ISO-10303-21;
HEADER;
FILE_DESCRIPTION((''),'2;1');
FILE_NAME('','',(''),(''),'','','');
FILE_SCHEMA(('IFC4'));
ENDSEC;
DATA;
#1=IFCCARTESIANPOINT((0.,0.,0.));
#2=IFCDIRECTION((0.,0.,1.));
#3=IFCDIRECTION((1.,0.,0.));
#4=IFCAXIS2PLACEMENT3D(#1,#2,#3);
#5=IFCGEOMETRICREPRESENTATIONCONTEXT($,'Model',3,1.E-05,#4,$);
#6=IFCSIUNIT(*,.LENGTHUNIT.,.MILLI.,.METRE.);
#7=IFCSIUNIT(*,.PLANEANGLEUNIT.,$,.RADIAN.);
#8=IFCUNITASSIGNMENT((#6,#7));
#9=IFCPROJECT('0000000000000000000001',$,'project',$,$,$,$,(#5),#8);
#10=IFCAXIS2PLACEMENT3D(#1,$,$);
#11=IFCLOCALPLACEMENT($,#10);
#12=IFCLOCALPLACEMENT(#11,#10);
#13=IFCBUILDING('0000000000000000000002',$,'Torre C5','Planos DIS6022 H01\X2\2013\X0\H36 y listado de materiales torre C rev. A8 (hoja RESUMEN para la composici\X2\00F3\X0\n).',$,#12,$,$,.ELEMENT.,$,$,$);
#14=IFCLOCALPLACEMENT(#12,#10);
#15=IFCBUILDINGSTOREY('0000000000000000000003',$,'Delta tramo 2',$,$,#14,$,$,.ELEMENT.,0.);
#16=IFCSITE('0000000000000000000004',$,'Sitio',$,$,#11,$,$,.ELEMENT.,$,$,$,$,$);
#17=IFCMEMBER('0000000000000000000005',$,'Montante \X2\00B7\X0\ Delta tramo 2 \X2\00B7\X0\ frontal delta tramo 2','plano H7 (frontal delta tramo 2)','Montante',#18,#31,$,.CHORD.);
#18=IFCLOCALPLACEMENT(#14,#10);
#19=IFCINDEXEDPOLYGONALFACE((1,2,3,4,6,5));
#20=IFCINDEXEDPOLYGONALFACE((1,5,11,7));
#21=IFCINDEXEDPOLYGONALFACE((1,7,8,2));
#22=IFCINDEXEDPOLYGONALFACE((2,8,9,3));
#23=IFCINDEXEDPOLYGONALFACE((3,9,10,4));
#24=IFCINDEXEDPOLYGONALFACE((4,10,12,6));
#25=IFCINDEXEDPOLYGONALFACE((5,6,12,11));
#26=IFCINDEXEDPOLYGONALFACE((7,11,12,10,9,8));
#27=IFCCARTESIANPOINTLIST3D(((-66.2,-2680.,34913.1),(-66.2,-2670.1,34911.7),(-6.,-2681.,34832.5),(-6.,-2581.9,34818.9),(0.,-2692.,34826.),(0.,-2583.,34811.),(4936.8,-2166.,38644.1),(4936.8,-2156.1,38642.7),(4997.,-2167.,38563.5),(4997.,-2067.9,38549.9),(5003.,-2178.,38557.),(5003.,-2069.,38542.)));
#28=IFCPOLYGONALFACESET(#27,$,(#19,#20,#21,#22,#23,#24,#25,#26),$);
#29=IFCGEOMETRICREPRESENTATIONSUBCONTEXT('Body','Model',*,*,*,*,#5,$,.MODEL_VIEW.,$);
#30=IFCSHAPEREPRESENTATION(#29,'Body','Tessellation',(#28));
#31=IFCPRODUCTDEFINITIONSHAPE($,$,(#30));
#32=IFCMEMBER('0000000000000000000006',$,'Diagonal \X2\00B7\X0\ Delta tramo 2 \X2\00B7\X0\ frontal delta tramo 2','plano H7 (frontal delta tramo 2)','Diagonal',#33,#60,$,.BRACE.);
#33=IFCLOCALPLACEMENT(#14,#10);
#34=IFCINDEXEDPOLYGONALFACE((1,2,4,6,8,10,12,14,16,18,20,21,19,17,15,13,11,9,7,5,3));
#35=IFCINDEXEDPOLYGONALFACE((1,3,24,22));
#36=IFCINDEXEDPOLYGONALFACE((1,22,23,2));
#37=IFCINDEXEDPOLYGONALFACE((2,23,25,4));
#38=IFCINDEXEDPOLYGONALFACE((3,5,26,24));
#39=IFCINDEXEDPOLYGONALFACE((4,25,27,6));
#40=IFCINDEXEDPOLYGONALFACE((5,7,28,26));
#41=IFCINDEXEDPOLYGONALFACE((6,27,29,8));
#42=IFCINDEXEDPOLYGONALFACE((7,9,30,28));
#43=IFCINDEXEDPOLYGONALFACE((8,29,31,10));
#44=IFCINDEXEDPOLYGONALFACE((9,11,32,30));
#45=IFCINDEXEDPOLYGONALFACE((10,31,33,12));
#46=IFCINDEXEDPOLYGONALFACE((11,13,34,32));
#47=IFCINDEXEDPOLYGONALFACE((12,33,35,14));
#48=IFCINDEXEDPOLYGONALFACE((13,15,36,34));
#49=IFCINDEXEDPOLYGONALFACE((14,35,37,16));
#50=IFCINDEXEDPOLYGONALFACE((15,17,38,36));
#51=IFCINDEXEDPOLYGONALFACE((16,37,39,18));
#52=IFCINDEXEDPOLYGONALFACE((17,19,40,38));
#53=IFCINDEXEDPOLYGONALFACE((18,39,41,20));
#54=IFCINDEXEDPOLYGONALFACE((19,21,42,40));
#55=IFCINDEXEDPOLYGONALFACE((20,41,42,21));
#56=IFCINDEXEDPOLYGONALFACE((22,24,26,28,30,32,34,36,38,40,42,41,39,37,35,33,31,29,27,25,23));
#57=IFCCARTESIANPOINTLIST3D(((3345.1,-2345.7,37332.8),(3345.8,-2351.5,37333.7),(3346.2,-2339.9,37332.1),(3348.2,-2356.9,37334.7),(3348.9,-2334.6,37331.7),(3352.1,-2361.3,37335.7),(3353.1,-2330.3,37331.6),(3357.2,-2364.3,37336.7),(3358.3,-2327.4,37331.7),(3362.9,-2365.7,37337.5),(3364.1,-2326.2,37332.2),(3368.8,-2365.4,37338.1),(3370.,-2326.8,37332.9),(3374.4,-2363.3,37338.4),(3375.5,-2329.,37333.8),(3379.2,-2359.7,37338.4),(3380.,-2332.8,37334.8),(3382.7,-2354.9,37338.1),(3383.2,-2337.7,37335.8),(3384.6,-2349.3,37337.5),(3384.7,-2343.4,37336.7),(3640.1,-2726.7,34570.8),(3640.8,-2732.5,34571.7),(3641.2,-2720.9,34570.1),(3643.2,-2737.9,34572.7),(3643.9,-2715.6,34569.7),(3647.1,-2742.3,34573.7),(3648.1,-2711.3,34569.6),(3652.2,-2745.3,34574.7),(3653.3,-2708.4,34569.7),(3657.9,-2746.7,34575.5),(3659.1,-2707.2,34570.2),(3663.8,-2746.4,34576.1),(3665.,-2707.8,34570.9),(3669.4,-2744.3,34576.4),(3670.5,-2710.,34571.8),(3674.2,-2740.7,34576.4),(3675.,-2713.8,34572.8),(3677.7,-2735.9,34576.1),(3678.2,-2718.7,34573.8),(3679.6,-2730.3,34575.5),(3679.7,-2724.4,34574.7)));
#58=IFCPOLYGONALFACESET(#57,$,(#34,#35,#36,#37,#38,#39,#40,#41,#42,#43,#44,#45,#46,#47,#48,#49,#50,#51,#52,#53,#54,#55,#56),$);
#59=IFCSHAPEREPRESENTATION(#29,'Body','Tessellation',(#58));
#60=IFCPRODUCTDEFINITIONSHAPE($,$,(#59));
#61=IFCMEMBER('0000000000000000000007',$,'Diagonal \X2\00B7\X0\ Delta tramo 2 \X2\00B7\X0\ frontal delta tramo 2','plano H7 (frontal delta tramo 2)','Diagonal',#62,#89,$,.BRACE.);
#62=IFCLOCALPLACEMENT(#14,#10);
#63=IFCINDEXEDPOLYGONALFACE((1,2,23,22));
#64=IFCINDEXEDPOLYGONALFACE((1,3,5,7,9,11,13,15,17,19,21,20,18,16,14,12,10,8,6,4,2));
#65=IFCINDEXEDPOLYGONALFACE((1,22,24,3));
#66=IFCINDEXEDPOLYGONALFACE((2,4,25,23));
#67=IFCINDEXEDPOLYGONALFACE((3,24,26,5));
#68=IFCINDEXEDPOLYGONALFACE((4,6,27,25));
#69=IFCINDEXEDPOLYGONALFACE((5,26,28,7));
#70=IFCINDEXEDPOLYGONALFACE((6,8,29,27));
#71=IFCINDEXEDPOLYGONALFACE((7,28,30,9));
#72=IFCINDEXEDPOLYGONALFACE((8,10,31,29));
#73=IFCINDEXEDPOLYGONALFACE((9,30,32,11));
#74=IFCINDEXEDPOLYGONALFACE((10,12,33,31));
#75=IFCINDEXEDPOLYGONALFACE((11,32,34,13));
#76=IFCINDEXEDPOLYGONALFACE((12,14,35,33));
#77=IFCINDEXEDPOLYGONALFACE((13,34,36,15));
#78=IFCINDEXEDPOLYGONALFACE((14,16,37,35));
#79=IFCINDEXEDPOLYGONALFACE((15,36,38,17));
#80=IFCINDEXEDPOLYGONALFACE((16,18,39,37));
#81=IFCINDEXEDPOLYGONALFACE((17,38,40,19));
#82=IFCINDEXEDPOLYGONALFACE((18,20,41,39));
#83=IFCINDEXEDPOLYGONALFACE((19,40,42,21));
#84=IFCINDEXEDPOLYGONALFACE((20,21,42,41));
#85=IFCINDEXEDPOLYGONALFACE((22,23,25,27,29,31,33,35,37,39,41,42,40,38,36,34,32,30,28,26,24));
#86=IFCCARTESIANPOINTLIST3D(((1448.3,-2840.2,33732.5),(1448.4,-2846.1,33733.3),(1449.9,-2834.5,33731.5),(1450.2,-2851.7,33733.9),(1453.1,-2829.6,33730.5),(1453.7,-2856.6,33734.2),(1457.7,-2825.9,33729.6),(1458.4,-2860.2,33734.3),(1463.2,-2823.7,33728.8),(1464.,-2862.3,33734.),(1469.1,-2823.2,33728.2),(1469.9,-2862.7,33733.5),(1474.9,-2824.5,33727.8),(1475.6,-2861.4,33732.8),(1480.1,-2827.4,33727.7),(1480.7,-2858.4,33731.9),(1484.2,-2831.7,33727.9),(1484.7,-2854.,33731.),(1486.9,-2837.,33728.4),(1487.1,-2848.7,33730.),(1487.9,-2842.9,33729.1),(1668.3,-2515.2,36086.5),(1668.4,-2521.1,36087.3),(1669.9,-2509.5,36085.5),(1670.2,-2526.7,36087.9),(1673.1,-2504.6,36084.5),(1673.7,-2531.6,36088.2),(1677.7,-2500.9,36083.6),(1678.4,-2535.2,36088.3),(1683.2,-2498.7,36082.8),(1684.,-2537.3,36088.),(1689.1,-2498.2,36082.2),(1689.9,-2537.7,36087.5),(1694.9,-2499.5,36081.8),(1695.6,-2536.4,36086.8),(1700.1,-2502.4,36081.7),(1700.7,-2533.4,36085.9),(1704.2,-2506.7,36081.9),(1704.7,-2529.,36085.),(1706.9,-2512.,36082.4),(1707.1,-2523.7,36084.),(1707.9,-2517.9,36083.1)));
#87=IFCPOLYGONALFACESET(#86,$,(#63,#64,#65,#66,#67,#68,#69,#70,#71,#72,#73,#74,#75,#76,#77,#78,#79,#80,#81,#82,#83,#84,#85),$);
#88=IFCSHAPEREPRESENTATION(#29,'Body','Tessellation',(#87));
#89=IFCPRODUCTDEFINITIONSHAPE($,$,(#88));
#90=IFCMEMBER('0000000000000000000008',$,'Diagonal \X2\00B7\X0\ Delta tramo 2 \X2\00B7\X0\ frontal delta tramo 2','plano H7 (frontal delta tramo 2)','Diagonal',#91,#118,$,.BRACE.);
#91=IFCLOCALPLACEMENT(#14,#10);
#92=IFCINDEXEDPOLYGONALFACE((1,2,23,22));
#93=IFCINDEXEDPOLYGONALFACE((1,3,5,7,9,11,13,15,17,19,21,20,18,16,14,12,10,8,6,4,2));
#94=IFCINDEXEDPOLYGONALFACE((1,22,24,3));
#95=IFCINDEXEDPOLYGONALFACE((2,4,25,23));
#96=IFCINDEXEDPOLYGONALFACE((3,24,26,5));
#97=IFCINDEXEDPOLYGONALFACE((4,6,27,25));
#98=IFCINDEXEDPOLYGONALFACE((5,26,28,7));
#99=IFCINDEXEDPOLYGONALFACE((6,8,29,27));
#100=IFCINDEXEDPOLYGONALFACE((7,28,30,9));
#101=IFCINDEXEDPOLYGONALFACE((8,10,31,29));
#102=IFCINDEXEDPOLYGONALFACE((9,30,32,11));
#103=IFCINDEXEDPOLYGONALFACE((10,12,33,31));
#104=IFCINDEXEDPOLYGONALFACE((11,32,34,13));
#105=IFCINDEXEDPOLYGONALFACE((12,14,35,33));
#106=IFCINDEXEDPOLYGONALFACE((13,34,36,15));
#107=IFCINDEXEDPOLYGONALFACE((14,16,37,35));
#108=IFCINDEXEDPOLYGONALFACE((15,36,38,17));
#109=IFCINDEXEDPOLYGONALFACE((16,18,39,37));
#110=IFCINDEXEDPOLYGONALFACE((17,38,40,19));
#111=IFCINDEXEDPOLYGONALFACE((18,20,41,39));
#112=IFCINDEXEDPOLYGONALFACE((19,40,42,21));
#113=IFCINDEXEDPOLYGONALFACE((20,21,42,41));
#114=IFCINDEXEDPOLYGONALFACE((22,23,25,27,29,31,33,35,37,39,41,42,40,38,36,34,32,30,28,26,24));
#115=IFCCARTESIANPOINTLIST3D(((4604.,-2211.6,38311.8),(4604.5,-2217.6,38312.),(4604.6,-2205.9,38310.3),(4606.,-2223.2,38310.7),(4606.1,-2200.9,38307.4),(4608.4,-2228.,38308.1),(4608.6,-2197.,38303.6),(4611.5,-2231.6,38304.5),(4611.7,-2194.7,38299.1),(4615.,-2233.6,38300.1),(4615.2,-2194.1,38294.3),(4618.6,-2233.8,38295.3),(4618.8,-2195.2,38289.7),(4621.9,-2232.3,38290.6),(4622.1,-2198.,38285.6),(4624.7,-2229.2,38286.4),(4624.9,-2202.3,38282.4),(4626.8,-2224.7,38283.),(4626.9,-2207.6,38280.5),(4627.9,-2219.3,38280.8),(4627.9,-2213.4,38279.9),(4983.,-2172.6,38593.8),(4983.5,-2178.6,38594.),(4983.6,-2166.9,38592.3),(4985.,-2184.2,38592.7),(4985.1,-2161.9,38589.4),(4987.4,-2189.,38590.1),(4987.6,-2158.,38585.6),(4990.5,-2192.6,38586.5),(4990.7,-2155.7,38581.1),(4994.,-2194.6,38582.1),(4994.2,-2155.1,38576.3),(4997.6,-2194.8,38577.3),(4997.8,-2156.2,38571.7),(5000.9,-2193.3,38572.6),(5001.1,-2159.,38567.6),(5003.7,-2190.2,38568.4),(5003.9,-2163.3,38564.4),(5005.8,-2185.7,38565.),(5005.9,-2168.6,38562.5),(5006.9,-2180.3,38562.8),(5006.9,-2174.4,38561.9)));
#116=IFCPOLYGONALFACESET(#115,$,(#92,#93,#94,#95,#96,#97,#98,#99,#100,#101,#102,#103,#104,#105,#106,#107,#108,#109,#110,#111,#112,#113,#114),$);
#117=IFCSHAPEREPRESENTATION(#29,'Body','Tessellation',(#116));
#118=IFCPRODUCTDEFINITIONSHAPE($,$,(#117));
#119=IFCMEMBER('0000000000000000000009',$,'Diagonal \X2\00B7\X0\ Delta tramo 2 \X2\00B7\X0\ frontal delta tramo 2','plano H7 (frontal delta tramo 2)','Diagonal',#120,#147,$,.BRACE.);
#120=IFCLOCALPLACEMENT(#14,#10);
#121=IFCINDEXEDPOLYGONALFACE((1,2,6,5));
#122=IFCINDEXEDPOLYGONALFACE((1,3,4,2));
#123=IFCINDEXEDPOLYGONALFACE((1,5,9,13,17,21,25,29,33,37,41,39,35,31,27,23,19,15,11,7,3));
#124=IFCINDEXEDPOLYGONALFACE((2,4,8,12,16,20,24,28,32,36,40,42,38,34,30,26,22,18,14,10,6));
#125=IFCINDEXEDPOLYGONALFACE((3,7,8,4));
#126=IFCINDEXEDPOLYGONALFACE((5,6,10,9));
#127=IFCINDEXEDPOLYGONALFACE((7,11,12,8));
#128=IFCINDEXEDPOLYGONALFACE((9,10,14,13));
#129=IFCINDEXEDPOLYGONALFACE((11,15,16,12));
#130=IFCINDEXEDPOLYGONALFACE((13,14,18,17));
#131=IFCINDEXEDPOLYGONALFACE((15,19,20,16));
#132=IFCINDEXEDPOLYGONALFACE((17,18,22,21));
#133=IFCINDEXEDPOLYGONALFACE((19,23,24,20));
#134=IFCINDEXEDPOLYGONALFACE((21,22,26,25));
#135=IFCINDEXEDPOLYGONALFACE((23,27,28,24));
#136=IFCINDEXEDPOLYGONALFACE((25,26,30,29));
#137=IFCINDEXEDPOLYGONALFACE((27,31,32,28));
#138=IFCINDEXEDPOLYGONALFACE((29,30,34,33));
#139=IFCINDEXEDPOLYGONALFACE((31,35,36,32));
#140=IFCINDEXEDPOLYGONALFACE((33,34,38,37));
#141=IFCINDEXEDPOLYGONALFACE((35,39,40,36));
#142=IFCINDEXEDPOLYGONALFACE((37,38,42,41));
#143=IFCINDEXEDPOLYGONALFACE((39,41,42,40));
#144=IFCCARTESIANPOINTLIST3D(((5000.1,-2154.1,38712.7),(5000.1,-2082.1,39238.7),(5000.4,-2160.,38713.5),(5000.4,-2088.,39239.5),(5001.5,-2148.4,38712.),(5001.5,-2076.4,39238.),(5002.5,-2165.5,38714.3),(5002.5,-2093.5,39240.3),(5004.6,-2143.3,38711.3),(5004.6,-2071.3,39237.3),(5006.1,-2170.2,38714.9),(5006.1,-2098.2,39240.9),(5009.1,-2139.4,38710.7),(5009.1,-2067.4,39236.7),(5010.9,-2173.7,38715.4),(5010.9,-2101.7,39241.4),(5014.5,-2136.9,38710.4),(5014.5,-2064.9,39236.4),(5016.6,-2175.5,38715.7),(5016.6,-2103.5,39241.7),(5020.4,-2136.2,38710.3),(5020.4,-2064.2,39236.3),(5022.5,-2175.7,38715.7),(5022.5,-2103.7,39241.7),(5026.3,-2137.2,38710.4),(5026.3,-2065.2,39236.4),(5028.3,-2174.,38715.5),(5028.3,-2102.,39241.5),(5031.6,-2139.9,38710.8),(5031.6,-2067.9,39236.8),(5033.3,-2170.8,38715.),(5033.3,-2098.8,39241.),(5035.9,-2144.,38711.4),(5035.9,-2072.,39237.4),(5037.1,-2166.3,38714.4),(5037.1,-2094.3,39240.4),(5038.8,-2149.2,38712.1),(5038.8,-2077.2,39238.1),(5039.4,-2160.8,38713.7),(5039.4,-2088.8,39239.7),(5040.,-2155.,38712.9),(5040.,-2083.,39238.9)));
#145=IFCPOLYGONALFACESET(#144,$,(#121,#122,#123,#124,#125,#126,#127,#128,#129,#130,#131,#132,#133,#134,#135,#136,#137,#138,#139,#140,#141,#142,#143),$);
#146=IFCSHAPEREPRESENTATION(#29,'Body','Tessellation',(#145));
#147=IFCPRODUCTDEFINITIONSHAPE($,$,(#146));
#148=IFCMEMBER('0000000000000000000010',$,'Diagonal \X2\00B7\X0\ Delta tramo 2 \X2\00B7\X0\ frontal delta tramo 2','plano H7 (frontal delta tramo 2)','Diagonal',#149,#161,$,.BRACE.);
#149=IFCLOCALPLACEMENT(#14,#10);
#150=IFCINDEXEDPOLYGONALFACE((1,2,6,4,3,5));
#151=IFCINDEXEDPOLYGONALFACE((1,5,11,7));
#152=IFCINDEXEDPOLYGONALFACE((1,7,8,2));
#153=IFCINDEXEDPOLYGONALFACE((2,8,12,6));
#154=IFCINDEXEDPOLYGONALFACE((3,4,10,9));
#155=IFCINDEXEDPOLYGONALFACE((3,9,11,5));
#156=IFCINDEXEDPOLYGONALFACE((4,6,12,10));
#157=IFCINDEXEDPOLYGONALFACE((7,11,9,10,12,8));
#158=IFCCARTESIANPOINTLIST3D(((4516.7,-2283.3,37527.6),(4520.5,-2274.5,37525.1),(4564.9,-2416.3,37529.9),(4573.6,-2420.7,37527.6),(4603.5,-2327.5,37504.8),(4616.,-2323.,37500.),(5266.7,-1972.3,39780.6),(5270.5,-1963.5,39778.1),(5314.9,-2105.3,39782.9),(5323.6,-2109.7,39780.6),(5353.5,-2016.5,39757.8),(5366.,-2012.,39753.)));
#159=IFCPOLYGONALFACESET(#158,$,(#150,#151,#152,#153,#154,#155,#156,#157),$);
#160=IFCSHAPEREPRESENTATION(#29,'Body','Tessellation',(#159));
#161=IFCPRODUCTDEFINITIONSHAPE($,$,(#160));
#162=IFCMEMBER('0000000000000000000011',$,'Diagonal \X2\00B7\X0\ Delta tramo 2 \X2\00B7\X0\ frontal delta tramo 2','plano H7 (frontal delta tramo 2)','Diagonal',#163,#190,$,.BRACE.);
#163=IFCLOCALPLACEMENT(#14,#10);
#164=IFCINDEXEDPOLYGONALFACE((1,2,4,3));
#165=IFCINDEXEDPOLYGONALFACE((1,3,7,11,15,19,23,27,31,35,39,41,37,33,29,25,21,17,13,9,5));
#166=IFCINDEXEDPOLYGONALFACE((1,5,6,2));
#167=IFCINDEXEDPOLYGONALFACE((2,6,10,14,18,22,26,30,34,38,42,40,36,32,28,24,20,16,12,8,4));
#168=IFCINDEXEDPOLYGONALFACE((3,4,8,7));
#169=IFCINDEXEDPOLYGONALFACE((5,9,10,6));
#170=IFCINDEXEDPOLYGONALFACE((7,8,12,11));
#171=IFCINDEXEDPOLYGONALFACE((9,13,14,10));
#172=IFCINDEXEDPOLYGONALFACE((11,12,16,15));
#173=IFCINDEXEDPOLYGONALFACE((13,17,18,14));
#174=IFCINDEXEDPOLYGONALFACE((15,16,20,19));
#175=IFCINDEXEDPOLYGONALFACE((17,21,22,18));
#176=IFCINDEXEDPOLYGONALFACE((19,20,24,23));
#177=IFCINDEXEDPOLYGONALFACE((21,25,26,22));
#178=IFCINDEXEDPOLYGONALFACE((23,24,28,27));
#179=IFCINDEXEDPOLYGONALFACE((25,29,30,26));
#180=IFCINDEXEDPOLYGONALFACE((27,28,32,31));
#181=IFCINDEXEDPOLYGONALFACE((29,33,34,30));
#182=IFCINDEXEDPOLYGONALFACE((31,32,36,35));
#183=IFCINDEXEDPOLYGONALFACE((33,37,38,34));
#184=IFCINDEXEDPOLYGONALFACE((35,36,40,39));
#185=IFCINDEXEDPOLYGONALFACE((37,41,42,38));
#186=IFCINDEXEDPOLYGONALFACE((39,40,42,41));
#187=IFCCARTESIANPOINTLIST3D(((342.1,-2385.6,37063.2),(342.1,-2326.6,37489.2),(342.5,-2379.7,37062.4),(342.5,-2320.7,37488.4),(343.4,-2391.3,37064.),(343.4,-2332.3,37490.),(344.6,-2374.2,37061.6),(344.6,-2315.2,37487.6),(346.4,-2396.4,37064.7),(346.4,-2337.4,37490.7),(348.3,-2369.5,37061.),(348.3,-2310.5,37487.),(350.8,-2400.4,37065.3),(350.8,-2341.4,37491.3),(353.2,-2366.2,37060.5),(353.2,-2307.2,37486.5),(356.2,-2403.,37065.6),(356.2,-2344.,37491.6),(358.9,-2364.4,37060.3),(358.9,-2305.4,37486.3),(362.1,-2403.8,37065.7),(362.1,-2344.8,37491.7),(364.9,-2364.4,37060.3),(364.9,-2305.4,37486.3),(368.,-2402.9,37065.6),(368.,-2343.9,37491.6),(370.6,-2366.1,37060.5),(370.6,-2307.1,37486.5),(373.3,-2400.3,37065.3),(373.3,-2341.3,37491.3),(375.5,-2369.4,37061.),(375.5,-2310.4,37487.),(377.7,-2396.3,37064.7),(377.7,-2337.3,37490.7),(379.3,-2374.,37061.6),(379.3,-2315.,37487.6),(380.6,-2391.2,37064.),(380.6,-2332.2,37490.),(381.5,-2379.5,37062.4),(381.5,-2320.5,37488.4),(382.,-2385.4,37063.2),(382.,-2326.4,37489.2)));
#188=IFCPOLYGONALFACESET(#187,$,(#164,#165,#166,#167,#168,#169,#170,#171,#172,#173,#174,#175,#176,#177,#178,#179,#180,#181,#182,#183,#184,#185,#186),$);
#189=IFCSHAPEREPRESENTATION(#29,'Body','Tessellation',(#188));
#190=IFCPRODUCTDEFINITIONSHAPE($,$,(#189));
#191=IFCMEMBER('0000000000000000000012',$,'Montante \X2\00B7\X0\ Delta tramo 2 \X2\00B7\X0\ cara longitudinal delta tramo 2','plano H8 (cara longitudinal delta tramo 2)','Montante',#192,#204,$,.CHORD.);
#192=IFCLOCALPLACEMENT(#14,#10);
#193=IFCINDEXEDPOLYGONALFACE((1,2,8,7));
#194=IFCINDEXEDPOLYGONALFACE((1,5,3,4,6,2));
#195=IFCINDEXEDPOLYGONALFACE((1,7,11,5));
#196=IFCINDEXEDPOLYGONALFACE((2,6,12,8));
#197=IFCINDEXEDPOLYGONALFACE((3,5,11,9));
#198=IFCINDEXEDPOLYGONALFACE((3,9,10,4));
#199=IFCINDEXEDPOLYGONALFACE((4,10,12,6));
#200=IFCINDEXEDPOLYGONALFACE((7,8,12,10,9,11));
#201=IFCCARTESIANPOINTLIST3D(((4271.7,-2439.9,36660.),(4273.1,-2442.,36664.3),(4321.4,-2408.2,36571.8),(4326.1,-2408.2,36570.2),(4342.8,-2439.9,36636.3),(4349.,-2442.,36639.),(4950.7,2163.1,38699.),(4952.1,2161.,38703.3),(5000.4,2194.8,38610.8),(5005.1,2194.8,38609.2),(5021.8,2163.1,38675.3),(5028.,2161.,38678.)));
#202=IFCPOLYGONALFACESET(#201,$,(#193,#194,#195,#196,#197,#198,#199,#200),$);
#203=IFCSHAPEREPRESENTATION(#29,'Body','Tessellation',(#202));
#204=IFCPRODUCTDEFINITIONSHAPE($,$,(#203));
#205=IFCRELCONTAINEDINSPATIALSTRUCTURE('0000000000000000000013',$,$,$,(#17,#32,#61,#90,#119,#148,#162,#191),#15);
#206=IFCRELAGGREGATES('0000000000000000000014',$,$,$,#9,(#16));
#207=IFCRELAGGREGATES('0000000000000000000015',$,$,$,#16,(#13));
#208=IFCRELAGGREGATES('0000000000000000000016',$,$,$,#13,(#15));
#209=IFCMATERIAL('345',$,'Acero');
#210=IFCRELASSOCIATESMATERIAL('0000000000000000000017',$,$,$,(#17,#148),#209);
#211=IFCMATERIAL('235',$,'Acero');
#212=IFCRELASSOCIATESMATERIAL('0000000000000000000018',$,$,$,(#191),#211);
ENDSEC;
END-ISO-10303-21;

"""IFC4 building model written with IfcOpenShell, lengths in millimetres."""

from ifc_helpers import new_model, si_unit, frame, frame_2d, origin, origin_with_axes, place, context, subcontext, project, spatial, circle, l_section, extrude, material, element, save


model = new_model("IFC4")

# Units and contexts
model_context = context("Model", 3, precision=1e-05, world=origin_with_axes())
body_context = subcontext(model_context, "Body", "Model", "MODEL_VIEW")
ifc_project = project(units=[si_unit("LENGTHUNIT", "METRE", prefix="MILLI"), si_unit("PLANEANGLEUNIT", "RADIAN")], contexts=[model_context])

# Site, building, storey
site_placement = place(None, origin())
site = spatial("IfcSite", under=ifc_project, at=site_placement, Name="Sitio", CompositionType="ELEMENT")
building_placement = place(site_placement, origin())
building = spatial("IfcBuilding", under=site, at=building_placement, Name="Torre C5", Description="Planos DIS6022 H01–H36 y listado de materiales torre C rev. A8 (hoja RESUMEN para la composición).", CompositionType="ELEMENT")
storey_placement = place(building_placement, origin())
storey = spatial("IfcBuildingStorey", under=building, at=storey_placement, Name="Delta tramo 2", CompositionType="ELEMENT", Elevation=0.0)

# Members
ifc_material_1 = material(Name="345", Category="Acero")
member_1_placement = place(storey_placement, frame((5003.0, -2178.0, 38557.0), z_axis=(-0.798926, -0.08208, -0.595801), x_axis=(-0.601429, 0.109034, 0.791451)))
element("IfcMember", 1, at=member_1_placement, inside=storey, material=ifc_material_1, Name="Montante · Delta tramo 2 · frontal delta tramo 2", Description="plano H7 (frontal delta tramo 2)", ObjectType="Montante", PredefinedType="CHORD", context=body_context, shape_type="SweptSolid", body=[
    extrude(l_section(Depth=110.0, Width=110.0, Thickness=10.0, at=frame_2d((55.0, 55.0))), None, (0.0, 0.0, 1.0), 6262.2),
])
member_2_placement = place(storey_placement, frame((3365.0, -2346.0, 37335.0), z_axis=(0.105217, -0.135891, -0.985121), x_axis=(-0.804373, 0.570852, -0.164658)))
element("IfcMember", 2, at=member_2_placement, inside=storey, Name="Diagonal · Delta tramo 2 · frontal delta tramo 2", Description="plano H7 (frontal delta tramo 2)", ObjectType="Diagonal", PredefinedType="BRACE", context=body_context, shape_type="SweptSolid", body=[
    extrude(circle(Radius=20.0), None, (0.0, 0.0, 1.0), 2803.7),
])
member_3_placement = place(storey_placement, frame((1688.0, -2518.0, 36085.0), z_axis=(-0.092186, -0.136183, -0.986385), x_axis=(-0.515108, 0.854278, -0.069803)))
element("IfcMember", 3, at=member_3_placement, inside=storey, Name="Diagonal · Delta tramo 2 · frontal delta tramo 2", Description="plano H7 (frontal delta tramo 2)", ObjectType="Diagonal", PredefinedType="BRACE", context=body_context, shape_type="SweptSolid", body=[
    extrude(circle(Radius=20.0), None, (0.0, 0.0, 1.0), 2386.5),
])
member_4_placement = place(storey_placement, frame((4995.0, -2175.0, 38578.0), z_axis=(-0.79956, -0.082277, -0.594923), x_axis=(-0.493108, 0.655414, 0.572081)))
element("IfcMember", 4, at=member_4_placement, inside=storey, Name="Diagonal · Delta tramo 2 · frontal delta tramo 2", Description="plano H7 (frontal delta tramo 2)", ObjectType="Diagonal", PredefinedType="BRACE", context=body_context, shape_type="SweptSolid", body=[
    extrude(circle(Radius=20.0), None, (0.0, 0.0, 1.0), 474.0),
])
member_5_placement = place(storey_placement, frame((5020.0, -2156.0, 38713.0), z_axis=(0.0, 0.135618, 0.990761), x_axis=(-0.922505, 0.382419, -0.052346)))
element("IfcMember", 5, at=member_5_placement, inside=storey, Name="Diagonal · Delta tramo 2 · frontal delta tramo 2", Description="plano H7 (frontal delta tramo 2)", ObjectType="Diagonal", PredefinedType="BRACE", context=body_context, shape_type="SweptSolid", body=[
    extrude(circle(Radius=20.0), None, (0.0, 0.0, 1.0), 530.9),
])
member_6_placement = place(storey_placement, frame((4616.0, -2323.0, 37500.0), z_axis=(0.313174, 0.129863, 0.940775), x_axis=(-0.867893, 0.441341, 0.22799)))
element("IfcMember", 6, at=member_6_placement, inside=storey, material=ifc_material_1, Name="Diagonal · Delta tramo 2 · frontal delta tramo 2", Description="plano H7 (frontal delta tramo 2)", ObjectType="Diagonal", PredefinedType="BRACE", context=body_context, shape_type="SweptSolid", body=[
    extrude(l_section(Depth=110.0, Width=110.0, Thickness=10.0, at=frame_2d((55.0, 55.0))), None, (0.0, 0.0, 1.0), 2394.8),
])
for number, where, z_axis, x_axis, name in (
    (7, (362.0, -2384.0, 37063.0), (0.0, 0.137188, 0.990545), (-0.153379, 0.978824, -0.135565), "Diagonal · Delta tramo 2 · frontal delta tramo 2"),
):
    element("IfcMember", number, at=place(storey_placement, frame(where, z_axis=z_axis, x_axis=x_axis)), inside=storey, Name=name, Description="plano H7 (frontal delta tramo 2)", ObjectType="Diagonal", PredefinedType="BRACE", context=body_context, shape_type="SweptSolid", body=[
        extrude(circle(Radius=20.0), None, (0.0, 0.0, 1.0), 430.1),
    ])
ifc_material_2 = material(Name="235", Category="Acero")
member_7_placement = place(storey_placement, frame((4349.0, -2442.0, 36639.0), z_axis=(0.133662, 0.906106, 0.40138), x_axis=(-0.286283, 0.42305, -0.859692)))
element("IfcMember", 8, at=member_7_placement, inside=storey, material=ifc_material_2, Name="Montante · Delta tramo 2 · cara longitudinal delta tramo 2", Description="plano H8 (cara longitudinal delta tramo 2)", ObjectType="Montante", PredefinedType="CHORD", context=body_context, shape_type="SweptSolid", body=[
    extrude(l_section(Depth=80.0, Width=80.0, Thickness=5.0, at=frame_2d((40.0, 40.0))), None, (0.0, 0.0, 1.0), 5080.0),
])

save(model, "model.ifc")
